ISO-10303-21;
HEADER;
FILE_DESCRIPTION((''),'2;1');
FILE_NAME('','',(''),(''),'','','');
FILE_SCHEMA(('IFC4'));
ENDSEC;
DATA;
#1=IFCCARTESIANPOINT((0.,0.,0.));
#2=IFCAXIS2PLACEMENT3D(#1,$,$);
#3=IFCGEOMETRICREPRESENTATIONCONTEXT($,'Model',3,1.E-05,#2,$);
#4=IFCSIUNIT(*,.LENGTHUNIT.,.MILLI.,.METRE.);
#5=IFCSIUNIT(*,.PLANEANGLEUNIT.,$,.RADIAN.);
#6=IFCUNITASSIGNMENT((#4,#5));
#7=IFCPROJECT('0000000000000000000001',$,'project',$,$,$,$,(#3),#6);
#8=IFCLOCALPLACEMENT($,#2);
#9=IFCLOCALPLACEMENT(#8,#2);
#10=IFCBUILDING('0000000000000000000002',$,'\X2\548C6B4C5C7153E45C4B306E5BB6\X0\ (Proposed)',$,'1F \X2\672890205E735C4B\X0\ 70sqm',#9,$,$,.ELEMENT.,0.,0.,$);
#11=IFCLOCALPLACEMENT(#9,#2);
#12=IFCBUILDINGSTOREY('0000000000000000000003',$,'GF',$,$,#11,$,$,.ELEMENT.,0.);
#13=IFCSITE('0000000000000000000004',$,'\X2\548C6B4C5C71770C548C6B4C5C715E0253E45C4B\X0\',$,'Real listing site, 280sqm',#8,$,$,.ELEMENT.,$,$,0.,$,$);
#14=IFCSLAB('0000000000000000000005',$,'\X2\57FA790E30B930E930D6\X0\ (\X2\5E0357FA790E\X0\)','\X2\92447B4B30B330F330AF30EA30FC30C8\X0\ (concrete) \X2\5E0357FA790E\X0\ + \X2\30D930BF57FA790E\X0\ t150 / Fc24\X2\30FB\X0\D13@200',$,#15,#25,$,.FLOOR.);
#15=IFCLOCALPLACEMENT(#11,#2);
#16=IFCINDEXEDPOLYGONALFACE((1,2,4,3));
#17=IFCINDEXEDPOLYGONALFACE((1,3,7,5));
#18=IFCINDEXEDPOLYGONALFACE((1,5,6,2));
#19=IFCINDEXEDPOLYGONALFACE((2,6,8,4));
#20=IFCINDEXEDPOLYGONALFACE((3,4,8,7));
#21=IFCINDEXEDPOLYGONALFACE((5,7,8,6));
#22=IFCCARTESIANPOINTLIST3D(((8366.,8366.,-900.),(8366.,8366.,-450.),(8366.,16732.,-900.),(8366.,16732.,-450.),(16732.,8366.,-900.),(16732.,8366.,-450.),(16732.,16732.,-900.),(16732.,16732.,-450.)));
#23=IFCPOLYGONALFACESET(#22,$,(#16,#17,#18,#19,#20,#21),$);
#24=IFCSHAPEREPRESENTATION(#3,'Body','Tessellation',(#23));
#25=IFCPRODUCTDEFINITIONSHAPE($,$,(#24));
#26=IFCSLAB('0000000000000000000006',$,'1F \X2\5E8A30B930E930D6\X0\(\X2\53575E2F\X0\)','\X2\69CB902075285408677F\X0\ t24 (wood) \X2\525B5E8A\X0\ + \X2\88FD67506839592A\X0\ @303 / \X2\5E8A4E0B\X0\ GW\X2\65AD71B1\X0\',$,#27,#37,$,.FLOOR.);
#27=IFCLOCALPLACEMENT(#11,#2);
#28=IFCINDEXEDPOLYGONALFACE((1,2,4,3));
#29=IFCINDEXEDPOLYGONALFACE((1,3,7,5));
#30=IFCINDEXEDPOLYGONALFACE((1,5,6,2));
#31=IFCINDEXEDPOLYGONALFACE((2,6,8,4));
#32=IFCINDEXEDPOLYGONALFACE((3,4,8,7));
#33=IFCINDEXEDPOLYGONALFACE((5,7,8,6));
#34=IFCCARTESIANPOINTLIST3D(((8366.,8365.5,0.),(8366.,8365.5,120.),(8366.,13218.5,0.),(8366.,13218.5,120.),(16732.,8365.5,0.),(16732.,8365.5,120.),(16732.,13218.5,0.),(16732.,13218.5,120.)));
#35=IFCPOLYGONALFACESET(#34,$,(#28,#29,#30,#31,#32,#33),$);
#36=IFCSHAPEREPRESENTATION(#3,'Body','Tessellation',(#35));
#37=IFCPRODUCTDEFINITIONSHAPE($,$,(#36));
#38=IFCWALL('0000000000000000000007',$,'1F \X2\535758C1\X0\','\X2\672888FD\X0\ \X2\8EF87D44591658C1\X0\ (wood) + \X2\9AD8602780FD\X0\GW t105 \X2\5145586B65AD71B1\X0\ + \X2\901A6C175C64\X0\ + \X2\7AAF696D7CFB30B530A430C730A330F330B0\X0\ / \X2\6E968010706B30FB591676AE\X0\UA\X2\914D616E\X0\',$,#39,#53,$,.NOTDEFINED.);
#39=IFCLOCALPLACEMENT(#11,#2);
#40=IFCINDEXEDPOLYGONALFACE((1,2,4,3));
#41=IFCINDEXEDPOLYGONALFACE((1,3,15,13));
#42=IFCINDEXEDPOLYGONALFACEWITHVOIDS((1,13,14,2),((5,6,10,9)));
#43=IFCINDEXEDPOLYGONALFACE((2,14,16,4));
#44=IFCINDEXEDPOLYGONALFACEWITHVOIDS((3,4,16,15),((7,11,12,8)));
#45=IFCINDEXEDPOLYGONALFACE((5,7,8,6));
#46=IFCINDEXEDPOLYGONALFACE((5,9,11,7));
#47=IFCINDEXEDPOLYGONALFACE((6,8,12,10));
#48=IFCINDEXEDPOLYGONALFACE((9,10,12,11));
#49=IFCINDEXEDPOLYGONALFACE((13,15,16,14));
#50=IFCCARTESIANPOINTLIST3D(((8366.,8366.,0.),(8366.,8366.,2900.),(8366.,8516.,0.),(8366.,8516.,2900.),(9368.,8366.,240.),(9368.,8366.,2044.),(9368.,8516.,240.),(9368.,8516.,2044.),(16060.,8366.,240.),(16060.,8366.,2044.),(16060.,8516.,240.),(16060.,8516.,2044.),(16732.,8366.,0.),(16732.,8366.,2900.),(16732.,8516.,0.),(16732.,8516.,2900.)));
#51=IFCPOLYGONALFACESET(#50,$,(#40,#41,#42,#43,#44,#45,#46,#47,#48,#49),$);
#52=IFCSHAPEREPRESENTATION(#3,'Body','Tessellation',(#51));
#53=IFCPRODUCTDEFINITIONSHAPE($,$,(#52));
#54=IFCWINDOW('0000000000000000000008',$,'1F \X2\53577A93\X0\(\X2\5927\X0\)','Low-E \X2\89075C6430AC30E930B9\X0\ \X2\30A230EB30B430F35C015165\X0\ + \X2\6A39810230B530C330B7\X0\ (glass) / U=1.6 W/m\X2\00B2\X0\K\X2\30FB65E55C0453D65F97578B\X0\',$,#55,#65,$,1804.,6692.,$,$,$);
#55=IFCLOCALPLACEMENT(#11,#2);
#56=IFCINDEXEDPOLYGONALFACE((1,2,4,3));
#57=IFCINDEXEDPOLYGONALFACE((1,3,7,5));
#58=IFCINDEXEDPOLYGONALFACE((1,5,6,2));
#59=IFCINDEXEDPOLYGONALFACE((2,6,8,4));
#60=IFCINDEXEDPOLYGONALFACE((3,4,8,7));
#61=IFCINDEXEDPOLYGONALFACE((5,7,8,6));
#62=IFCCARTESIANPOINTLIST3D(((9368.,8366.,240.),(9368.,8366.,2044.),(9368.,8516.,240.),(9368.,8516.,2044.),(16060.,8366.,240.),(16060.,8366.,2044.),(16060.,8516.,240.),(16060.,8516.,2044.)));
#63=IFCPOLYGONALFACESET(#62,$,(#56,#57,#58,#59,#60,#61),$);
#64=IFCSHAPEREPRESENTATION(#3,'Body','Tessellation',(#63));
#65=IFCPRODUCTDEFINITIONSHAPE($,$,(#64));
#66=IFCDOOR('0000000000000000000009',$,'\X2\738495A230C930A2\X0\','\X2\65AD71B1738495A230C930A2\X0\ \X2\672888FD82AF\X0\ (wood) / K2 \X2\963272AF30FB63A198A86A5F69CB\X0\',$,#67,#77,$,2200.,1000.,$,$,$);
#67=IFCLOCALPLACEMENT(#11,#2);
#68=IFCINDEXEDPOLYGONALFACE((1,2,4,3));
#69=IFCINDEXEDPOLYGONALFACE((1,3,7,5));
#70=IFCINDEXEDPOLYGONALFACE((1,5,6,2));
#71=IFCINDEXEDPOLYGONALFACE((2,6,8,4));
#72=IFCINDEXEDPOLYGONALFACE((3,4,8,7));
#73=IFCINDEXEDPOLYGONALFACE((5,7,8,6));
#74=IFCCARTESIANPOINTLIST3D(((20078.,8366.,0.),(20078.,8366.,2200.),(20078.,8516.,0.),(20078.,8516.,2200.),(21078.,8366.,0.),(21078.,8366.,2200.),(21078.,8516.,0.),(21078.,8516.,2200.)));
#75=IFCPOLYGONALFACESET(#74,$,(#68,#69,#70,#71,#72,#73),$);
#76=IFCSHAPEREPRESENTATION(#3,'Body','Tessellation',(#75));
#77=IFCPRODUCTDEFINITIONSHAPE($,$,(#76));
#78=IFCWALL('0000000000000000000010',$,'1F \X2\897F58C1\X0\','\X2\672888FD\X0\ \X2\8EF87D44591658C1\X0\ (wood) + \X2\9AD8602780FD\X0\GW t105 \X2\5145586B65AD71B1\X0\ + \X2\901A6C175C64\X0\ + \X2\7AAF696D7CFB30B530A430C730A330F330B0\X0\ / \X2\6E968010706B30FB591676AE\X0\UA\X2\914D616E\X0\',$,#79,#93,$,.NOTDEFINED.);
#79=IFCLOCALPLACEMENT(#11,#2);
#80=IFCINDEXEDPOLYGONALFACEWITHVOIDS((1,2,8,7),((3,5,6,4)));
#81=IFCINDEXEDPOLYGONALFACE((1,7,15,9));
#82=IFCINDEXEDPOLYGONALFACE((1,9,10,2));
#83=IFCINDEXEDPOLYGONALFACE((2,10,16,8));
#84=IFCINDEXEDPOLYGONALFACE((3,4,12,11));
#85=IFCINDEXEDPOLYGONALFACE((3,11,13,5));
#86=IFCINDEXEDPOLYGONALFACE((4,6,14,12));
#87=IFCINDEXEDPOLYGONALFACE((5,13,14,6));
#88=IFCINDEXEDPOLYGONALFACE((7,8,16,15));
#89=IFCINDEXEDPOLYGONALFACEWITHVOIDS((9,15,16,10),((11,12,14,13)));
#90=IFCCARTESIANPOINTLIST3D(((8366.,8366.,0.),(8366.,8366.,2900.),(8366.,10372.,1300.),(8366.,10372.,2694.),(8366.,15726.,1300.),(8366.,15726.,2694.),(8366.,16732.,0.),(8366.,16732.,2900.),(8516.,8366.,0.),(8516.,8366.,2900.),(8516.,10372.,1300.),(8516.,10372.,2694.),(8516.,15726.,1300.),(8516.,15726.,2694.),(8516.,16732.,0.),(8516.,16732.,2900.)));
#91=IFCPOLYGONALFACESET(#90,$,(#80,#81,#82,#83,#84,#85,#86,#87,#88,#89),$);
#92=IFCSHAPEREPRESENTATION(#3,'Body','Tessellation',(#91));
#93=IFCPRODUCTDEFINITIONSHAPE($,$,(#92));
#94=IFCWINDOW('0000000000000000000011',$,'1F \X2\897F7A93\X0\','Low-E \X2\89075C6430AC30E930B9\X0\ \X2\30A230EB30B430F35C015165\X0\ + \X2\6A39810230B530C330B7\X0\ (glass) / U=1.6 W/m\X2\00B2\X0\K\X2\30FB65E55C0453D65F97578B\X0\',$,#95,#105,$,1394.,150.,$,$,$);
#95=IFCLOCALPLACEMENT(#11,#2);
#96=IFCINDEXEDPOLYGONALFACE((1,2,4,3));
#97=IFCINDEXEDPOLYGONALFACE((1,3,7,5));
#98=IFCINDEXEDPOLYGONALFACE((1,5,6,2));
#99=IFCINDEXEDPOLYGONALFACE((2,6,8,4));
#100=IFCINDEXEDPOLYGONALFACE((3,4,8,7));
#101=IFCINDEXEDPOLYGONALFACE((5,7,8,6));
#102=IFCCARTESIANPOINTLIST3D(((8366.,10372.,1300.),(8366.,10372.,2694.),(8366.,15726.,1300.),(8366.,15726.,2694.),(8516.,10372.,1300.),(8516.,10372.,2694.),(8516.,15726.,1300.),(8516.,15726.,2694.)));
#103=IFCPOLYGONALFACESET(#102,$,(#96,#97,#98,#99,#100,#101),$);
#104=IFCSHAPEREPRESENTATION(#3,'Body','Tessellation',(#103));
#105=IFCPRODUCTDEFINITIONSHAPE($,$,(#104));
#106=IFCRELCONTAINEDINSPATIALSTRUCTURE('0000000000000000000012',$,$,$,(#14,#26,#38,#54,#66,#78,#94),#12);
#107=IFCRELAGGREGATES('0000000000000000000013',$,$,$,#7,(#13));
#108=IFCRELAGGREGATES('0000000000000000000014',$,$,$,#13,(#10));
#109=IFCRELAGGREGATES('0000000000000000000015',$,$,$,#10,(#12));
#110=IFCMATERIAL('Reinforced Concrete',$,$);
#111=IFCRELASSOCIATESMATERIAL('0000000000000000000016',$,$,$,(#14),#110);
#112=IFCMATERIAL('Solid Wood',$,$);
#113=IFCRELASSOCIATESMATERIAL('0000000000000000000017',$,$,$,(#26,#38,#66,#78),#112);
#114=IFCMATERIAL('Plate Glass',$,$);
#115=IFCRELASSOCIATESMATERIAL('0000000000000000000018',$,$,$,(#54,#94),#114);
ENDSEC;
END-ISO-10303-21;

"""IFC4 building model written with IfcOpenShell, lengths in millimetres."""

from ifc_helpers import new_model, si_unit, frame, frame_2d, origin, place, context, project, spatial, rectangle, extrude, material, element, fill, save


model = new_model("IFC4")

# Units and contexts
model_context = context("Model", 3, precision=1e-05, world=origin())
ifc_project = project(units=[si_unit("LENGTHUNIT", "METRE", prefix="MILLI"), si_unit("PLANEANGLEUNIT", "RADIAN")], contexts=[model_context])

# Site, building, storey
site_placement = place(None, origin())
site = spatial("IfcSite", under=ifc_project, at=site_placement, Name="和歌山県和歌山市古屋", ObjectType="Real listing site, 280sqm", CompositionType="ELEMENT", RefElevation=0.0)
building_placement = place(site_placement, origin())
building = spatial("IfcBuilding", under=site, at=building_placement, Name="和歌山古屋の家 (Proposed)", ObjectType="1F 木造平屋 70sqm", CompositionType="ELEMENT", ElevationOfRefHeight=0.0, ElevationOfTerrain=0.0)
storey_placement = place(building_placement, origin())
storey = spatial("IfcBuildingStorey", under=building, at=storey_placement, Name="GF", CompositionType="ELEMENT", Elevation=0.0)

# Slabs
ifc_material_1 = material(Name="Reinforced Concrete")
slab_1_placement = place(storey_placement, frame((4183.0, 4183.0, -450.0)))
element("IfcSlab", 1, at=slab_1_placement, inside=storey, material=ifc_material_1, Name="基礎スラブ (布基礎)", Description="鉄筋コンクリート (concrete) 布基礎 + ベタ基礎 t150 / Fc24・D13@200", PredefinedType="FLOOR", context=model_context, shape_type="SweptSolid", body=[
    extrude(rectangle(XDim=8366.0, YDim=8366.0, at=frame_2d((4183.0, 4183.0))), frame((4183.0, 4183.0, -450.0)), (0.0, 0.0, 1.0), 450.0),
])
ifc_material_2 = material(Name="Solid Wood")
slab_2_placement = place(storey_placement, frame((4183.0, 4183.0, 0.0)))
element("IfcSlab", 2, at=slab_2_placement, inside=storey, material=ifc_material_2, Name="1F 床スラブ(南帯)", Description="構造用合板 t24 (wood) 剛床 + 製材根太 @303 / 床下 GW断熱", PredefinedType="FLOOR", context=model_context, shape_type="SweptSolid", body=[
    extrude(rectangle(XDim=8366.0, YDim=4853.0, at=frame_2d((4183.0, 2426.0))), frame((4183.0, 4183.0, 0.0)), (0.0, 0.0, 1.0), 120.0),
])

# Wall, openings, window, door
wall_1_placement = place(storey_placement, frame((4183.0, 4183.0, 0.0)))
wall_1 = element("IfcWall", 3, at=wall_1_placement, inside=storey, material=ifc_material_2, Name="1F 南壁", Description="木製 軸組外壁 (wood) + 高性能GW t105 充填断熱 + 通気層 + 窯業系サイディング / 準耐火・外皮UA配慮", PredefinedType="NOTDEFINED", context=model_context, shape_type="SweptSolid", body=[
    extrude(rectangle(XDim=8366.0, YDim=150.0, at=frame_2d((4183.0, 75.0))), frame((4183.0, 4183.0, 0.0)), (0.0, 0.0, 1.0), 2900.0),
])
opening_1_placement = place(storey_placement, frame((4684.0, 4183.0, 120.0)))
opening_1 = element("IfcOpeningElement", 4, at=opening_1_placement, cuts=wall_1, PredefinedType="NOTDEFINED", context=model_context, shape_type="SweptSolid", body=[
    extrude(rectangle(XDim=6692.0, YDim=150.0, at=frame_2d((3346.0, 75.0))), frame((4684.0, 4183.0, 120.0)), (0.0, 0.0, 1.0), 1804.0),
])
opening_2_placement = place(storey_placement, frame((10039.0, 4183.0, 0.0)))
opening_2 = element("IfcOpeningElement", 5, at=opening_2_placement, cuts=wall_1, PredefinedType="NOTDEFINED", context=model_context, shape_type="SweptSolid", body=[
    extrude(rectangle(XDim=1000.0, YDim=150.0, at=frame_2d((500.0, 75.0))), frame((10039.0, 4183.0, 0.0)), (0.0, 0.0, 1.0), 2200.0),
])
ifc_material_3 = material(Name="Plate Glass")
window_1_placement = place(storey_placement, frame((4684.0, 4183.0, 120.0)))
window_1 = element("IfcWindow", 6, at=window_1_placement, inside=storey, material=ifc_material_3, Name="1F 南窓(大)", Description="Low-E 複層ガラス アルゴン封入 + 樹脂サッシ (glass) / U=1.6 W/m²K・日射取得型", OverallHeight=1804.0, OverallWidth=6692.0, context=model_context, shape_type="SweptSolid", body=[
    extrude(rectangle(XDim=6692.0, YDim=150.0, at=frame_2d((3346.0, 75.0))), frame((4684.0, 4183.0, 120.0)), (0.0, 0.0, 1.0), 1804.0),
])
fill(opening_1, window_1)
door_placement = place(storey_placement, frame((10039.0, 4183.0, 0.0)))
door = element("IfcDoor", 7, at=door_placement, inside=storey, material=ifc_material_2, Name="玄関ドア", Description="断熱玄関ドア 木製芯 (wood) / K2 防犯・採風機構", OverallHeight=2200.0, OverallWidth=1000.0, context=model_context, shape_type="SweptSolid", body=[
    extrude(rectangle(XDim=1000.0, YDim=150.0, at=frame_2d((500.0, 75.0))), frame((10039.0, 4183.0, 0.0)), (0.0, 0.0, 1.0), 2200.0),
])
fill(opening_2, door)

# Wall, opening, window
wall_2_placement = place(storey_placement, frame((4183.0, 4183.0, 0.0)))
wall_2 = element("IfcWall", 8, at=wall_2_placement, inside=storey, material=ifc_material_2, Name="1F 西壁", Description="木製 軸組外壁 (wood) + 高性能GW t105 充填断熱 + 通気層 + 窯業系サイディング / 準耐火・外皮UA配慮", PredefinedType="NOTDEFINED", context=model_context, shape_type="SweptSolid", body=[
    extrude(rectangle(XDim=150.0, YDim=8366.0, at=frame_2d((75.0, 4183.0))), frame((4183.0, 4183.0, 0.0)), (0.0, 0.0, 1.0), 2900.0),
])
opening_3_placement = place(storey_placement, frame((4183.0, 5186.0, 650.0)))
opening_3 = element("IfcOpeningElement", 9, at=opening_3_placement, cuts=wall_2, PredefinedType="NOTDEFINED", context=model_context, shape_type="SweptSolid", body=[
    extrude(rectangle(XDim=150.0, YDim=5354.0, at=frame_2d((75.0, 2677.0))), frame((4183.0, 5186.0, 650.0)), (0.0, 0.0, 1.0), 1394.0),
])
window_2_placement = place(storey_placement, frame((4183.0, 5186.0, 650.0)))
window_2 = element("IfcWindow", 10, at=window_2_placement, inside=storey, material=ifc_material_3, Name="1F 西窓", Description="Low-E 複層ガラス アルゴン封入 + 樹脂サッシ (glass) / U=1.6 W/m²K・日射取得型", OverallHeight=1394.0, OverallWidth=150.0, context=model_context, shape_type="SweptSolid", body=[
    extrude(rectangle(XDim=150.0, YDim=5354.0, at=frame_2d((75.0, 2677.0))), frame((4183.0, 5186.0, 650.0)), (0.0, 0.0, 1.0), 1394.0),
])
fill(opening_3, window_2)

save(model, "model.ifc")
